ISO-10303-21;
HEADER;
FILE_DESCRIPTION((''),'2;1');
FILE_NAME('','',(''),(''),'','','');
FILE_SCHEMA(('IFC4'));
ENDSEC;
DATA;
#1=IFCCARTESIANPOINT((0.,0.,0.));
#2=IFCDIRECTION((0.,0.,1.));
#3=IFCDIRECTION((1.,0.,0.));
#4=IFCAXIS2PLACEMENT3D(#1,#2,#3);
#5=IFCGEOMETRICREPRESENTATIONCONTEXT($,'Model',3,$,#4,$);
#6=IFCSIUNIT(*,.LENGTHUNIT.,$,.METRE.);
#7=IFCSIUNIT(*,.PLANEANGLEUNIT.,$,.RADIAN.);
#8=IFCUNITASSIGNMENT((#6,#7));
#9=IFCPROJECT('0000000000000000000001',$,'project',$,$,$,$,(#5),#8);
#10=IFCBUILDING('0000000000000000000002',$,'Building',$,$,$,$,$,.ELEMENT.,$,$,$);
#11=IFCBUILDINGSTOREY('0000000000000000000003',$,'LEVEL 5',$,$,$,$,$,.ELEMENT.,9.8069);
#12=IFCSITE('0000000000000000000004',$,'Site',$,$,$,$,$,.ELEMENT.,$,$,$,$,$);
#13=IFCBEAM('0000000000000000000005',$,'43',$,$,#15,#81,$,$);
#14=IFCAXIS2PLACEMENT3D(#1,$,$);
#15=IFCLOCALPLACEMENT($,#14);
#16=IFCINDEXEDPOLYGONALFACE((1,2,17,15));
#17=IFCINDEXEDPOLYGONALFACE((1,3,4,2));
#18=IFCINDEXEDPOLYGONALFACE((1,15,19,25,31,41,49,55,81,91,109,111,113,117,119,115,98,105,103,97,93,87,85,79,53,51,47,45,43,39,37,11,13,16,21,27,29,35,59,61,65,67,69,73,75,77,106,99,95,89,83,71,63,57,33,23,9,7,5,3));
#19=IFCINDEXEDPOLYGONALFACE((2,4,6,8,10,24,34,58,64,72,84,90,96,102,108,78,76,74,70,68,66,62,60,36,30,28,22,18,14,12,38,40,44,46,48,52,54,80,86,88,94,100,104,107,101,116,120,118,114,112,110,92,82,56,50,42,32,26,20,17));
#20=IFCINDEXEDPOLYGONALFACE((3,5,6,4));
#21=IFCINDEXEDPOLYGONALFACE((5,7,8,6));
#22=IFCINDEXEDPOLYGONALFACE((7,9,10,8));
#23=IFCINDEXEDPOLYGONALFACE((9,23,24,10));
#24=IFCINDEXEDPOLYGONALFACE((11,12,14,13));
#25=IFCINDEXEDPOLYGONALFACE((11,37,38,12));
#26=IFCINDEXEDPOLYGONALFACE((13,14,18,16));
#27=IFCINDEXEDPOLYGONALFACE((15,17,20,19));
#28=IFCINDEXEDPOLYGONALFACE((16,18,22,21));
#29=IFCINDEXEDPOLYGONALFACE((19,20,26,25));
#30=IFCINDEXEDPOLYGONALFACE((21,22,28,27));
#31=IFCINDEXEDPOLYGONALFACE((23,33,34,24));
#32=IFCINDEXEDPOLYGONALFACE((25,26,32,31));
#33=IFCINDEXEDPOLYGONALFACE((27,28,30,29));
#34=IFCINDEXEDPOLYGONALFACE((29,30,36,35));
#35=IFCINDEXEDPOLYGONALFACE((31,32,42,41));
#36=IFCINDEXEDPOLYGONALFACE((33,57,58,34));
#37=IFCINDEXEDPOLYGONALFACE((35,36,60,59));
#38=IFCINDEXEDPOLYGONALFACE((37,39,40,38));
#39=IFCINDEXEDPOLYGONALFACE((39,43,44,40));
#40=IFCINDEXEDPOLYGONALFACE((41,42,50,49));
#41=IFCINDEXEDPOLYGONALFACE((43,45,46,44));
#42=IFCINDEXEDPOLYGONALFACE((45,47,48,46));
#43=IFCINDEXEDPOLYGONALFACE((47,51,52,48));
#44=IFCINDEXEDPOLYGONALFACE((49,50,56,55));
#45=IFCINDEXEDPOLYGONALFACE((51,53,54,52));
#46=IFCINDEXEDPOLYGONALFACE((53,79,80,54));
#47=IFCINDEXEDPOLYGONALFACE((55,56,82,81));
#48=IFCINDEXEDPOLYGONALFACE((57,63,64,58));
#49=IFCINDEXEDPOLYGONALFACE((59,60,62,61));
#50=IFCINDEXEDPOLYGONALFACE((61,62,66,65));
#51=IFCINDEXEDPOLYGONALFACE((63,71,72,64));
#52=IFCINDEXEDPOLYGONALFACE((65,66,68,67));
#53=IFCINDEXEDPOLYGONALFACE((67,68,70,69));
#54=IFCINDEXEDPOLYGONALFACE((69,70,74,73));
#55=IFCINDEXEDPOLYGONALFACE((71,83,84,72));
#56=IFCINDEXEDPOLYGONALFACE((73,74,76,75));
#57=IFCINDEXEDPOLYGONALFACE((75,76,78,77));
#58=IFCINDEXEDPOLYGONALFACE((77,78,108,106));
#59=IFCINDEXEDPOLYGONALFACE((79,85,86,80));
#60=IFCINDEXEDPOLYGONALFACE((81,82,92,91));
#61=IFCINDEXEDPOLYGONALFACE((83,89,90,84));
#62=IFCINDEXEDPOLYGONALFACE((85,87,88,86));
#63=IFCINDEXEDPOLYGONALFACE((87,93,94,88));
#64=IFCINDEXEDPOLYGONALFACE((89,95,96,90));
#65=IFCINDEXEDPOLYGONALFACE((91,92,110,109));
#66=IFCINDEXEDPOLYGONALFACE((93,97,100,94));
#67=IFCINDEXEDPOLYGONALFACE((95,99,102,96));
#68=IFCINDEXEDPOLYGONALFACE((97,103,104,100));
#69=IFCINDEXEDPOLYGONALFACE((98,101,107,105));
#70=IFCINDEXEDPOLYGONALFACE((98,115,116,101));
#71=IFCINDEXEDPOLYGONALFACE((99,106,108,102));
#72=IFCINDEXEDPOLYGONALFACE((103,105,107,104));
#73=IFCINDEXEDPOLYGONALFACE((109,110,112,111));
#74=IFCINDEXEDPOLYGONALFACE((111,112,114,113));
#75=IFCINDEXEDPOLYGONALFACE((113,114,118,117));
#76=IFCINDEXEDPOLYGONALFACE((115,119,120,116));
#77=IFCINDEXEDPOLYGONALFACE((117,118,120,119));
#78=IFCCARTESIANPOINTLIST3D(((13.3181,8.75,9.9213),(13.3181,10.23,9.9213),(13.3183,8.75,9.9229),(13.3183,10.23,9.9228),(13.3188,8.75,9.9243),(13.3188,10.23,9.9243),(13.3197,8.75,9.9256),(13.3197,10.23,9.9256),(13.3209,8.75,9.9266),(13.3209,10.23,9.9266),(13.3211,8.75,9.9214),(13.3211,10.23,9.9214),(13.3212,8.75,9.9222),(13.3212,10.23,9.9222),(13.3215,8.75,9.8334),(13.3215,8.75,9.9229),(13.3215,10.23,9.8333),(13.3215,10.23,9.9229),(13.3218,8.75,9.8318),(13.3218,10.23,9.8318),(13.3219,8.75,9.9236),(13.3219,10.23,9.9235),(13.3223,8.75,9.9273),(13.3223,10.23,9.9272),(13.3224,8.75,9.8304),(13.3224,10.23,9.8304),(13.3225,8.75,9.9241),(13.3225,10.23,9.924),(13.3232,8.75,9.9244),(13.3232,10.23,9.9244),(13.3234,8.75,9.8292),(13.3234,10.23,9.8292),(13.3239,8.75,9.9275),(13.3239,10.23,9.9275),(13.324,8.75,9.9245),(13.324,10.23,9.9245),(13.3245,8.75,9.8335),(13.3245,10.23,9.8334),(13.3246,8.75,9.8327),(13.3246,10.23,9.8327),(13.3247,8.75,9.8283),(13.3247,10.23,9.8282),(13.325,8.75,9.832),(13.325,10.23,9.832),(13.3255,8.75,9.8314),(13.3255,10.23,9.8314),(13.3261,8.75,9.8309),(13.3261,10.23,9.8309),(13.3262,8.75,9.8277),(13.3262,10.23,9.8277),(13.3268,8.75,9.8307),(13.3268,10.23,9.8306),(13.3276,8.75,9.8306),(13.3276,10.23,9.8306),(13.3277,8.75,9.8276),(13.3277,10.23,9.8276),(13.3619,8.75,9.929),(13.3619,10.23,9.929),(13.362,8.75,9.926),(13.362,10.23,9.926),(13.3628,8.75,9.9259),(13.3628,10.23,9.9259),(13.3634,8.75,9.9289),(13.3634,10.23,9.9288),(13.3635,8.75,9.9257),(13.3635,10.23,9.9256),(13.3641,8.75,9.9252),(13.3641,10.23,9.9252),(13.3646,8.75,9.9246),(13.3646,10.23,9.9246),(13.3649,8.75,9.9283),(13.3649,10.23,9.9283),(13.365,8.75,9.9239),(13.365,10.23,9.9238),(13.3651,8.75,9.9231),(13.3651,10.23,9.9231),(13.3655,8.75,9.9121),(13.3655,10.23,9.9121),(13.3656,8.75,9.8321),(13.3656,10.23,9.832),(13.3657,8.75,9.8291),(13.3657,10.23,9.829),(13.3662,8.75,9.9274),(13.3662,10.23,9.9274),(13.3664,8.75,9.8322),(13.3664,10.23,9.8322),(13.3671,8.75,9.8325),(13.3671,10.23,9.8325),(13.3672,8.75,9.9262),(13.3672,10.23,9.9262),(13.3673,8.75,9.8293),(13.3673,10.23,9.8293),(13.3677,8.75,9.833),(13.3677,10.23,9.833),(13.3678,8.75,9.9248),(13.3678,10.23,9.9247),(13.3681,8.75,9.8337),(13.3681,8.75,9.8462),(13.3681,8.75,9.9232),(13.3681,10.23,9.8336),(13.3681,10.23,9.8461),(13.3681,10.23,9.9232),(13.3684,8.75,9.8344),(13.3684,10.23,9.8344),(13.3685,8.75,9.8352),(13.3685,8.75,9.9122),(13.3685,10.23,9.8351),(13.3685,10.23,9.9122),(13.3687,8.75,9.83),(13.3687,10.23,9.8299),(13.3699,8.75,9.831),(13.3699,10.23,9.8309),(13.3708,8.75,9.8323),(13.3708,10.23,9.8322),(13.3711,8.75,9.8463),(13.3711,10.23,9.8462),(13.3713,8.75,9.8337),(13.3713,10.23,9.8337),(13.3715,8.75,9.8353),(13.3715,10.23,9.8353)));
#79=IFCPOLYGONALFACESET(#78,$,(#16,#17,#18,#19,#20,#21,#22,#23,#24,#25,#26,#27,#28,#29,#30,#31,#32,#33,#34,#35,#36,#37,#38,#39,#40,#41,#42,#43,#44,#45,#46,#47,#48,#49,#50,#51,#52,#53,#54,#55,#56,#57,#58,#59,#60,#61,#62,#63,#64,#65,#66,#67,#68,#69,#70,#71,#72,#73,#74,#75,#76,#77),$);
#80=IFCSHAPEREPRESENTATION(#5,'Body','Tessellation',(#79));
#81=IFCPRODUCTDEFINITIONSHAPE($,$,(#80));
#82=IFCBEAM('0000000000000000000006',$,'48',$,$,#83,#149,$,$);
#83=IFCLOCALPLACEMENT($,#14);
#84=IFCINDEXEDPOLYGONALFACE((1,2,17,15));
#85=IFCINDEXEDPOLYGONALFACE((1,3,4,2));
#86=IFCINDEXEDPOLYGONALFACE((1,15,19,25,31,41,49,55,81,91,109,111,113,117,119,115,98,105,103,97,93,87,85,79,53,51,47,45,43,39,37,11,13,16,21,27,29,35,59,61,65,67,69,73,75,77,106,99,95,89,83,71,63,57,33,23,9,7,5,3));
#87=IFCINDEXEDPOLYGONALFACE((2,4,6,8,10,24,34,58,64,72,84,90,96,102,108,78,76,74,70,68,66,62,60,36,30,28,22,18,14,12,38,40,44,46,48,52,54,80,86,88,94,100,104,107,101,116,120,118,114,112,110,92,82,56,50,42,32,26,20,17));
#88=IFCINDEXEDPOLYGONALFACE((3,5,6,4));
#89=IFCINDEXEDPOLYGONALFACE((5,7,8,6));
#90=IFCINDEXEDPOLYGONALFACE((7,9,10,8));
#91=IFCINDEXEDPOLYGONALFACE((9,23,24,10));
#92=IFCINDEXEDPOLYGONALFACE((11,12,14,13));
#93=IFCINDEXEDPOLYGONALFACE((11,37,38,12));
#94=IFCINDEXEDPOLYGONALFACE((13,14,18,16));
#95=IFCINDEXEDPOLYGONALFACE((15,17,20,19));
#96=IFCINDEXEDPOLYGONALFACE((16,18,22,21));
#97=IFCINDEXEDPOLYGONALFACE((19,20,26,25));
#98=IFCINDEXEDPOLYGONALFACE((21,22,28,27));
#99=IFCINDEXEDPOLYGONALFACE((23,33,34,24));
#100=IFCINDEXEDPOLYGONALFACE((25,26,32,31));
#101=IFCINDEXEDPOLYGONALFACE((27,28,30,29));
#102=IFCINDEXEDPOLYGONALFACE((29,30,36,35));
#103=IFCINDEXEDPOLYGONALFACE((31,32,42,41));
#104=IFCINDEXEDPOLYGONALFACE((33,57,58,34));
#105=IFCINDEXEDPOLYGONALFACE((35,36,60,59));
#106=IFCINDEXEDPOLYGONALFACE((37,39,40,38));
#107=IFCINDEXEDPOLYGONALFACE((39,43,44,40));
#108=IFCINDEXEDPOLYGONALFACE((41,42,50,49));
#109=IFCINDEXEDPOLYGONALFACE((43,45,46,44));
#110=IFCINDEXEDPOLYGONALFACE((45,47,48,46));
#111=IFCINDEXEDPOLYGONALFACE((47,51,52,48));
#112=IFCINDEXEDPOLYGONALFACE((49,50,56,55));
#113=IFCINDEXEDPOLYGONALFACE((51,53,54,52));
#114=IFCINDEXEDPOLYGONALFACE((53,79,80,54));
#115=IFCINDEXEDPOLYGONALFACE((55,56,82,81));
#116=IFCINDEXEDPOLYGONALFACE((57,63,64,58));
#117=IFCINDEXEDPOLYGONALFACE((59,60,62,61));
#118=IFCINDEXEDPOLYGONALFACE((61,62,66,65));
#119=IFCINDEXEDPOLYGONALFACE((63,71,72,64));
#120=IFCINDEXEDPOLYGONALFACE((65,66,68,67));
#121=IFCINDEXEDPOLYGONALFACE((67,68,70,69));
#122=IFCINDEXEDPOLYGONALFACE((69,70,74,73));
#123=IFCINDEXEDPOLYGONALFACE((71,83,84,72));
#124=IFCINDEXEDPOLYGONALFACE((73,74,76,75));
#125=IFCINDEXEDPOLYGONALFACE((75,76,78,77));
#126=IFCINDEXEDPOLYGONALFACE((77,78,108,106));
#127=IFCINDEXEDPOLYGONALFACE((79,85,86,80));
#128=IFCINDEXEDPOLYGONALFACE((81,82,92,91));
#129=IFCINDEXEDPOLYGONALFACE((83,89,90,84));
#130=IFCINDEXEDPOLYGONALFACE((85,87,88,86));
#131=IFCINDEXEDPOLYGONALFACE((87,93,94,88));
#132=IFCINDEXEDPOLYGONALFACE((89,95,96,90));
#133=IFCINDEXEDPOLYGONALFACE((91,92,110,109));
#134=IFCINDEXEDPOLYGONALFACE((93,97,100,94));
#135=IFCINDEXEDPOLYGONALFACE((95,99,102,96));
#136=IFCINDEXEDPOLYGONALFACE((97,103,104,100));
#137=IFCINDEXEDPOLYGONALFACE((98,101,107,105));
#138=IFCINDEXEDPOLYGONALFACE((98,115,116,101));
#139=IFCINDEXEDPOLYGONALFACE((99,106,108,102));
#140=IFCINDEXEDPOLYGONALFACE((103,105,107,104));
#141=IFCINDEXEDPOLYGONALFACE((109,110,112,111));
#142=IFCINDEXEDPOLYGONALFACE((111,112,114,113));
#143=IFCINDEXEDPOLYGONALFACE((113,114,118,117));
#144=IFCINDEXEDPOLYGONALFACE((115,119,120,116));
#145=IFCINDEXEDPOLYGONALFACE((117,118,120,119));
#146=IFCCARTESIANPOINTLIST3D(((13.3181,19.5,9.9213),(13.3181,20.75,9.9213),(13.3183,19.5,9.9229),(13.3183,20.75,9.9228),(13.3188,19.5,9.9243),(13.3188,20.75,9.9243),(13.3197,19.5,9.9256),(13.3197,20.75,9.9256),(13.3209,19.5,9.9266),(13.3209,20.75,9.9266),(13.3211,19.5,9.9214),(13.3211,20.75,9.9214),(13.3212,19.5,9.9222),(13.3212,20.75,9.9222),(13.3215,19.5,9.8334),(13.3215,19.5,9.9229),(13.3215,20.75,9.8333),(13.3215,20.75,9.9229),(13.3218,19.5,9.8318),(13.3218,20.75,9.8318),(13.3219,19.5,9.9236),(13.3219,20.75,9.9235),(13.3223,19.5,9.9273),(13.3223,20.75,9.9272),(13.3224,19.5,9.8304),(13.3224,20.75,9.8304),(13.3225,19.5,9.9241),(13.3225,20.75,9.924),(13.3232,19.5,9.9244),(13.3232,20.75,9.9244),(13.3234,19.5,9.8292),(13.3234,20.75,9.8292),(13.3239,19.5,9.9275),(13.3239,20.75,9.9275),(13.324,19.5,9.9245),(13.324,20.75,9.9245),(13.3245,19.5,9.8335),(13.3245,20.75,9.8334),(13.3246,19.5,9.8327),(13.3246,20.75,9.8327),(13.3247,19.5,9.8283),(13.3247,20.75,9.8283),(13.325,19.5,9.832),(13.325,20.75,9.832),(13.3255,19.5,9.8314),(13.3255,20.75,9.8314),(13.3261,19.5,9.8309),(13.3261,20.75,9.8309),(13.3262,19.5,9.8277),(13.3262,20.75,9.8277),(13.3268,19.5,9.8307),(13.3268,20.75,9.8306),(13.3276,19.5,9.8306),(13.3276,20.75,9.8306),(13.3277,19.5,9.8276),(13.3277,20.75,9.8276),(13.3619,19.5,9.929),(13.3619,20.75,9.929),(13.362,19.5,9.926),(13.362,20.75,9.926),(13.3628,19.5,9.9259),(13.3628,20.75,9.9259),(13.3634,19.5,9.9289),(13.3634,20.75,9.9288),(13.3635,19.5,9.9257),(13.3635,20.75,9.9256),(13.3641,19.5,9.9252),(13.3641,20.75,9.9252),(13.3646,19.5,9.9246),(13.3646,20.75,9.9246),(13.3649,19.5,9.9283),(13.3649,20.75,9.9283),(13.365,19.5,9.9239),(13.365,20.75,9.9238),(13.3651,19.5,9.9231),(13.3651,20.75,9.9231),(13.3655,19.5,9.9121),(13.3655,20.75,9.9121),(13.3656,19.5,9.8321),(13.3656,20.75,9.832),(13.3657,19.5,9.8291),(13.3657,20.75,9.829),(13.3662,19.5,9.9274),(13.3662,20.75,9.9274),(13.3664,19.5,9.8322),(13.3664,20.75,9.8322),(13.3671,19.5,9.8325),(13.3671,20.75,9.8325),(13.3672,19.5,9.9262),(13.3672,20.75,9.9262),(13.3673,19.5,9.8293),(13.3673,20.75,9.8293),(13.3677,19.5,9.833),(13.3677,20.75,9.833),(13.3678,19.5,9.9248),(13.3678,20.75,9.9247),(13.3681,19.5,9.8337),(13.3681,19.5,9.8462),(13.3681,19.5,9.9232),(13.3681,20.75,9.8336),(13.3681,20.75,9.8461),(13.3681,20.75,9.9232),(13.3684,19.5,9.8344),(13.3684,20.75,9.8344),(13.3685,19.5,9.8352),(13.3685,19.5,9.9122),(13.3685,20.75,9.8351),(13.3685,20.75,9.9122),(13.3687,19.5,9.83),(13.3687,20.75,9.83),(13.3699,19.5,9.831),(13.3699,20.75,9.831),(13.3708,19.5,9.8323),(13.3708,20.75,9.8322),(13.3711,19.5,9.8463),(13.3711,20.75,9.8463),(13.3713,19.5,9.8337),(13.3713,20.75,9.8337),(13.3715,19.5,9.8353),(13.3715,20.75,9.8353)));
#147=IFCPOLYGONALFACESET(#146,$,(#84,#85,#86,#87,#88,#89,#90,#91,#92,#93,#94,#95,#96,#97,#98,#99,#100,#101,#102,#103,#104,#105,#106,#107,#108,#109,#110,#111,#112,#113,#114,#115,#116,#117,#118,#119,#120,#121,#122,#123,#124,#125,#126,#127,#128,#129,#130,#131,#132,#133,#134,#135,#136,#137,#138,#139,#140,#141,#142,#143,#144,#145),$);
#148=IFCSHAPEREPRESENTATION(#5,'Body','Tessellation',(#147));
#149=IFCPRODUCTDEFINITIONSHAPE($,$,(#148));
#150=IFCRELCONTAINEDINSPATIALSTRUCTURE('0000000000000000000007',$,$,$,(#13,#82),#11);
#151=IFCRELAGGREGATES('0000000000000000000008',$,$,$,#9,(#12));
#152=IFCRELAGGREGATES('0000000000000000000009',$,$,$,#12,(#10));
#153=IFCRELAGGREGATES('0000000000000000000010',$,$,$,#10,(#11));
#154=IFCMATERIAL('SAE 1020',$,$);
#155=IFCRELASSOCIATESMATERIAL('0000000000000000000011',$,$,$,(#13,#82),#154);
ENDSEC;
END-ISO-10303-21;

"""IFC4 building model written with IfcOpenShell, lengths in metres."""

from ifc_helpers import new_model, si_unit, frame, origin_with_axes, origin_2d_with_axis, place, context, project, spatial, c_section, extrude, material, material_profile, profile_set, profile_usage, element, save


model = new_model("IFC4")

# Units and contexts
model_context = context("Model", 3, world=origin_with_axes())
ifc_project = project(units=[si_unit("LENGTHUNIT", "METRE"), si_unit("PLANEANGLEUNIT", "RADIAN")], contexts=[model_context])

# Site, building, storey
site = spatial("IfcSite", under=ifc_project, Name="Site", CompositionType="ELEMENT")
building = spatial("IfcBuilding", under=site, Name="Building", CompositionType="ELEMENT")
storey = spatial("IfcBuildingStorey", under=building, Name="LEVEL 5", CompositionType="ELEMENT", Elevation=9.8069)

# Beams
ifc_material = material(Name="SAE 1020")
ifc_material_profile_1 = material_profile(ifc_material, c_section(Depth=0.1, Width=0.05, WallThickness=0.003, Girth=0.017, InternalFilletRadius=0.003, at=origin_2d_with_axis()))
ifc_profile_set_1 = profile_set([ifc_material_profile_1])
ifc_profile_usage_1 = profile_usage(ifc_profile_set_1, cardinal=10)
beam_1_placement = place(None, frame((13.3448, 8.75, 9.8783), z_axis=(0.0, 1.0, -0.00003), x_axis=(0.999256, 0.000001, 0.038562)))
element("IfcBeam", 1, at=beam_1_placement, inside=storey, material=ifc_profile_usage_1, Name="43", context=model_context, shape_type="SweptSolid", body=[
    extrude(c_section(Depth=0.1, Width=0.05, WallThickness=0.003, Girth=0.017, InternalFilletRadius=0.003, at=origin_2d_with_axis()), origin_with_axes(), (0.0, 0.0, 1.0), 1.48),
])
ifc_material_profile_2 = material_profile(ifc_material, c_section(Depth=0.1, Width=0.05, WallThickness=0.003, Girth=0.017, InternalFilletRadius=0.003, at=origin_2d_with_axis()))
ifc_profile_set_2 = profile_set([ifc_material_profile_2])
ifc_profile_usage_2 = profile_usage(ifc_profile_set_2, cardinal=10)
beam_2_placement = place(None, frame((13.3448, 19.5, 9.8783), z_axis=(0.0, 1.0, -0.00003), x_axis=(0.999256, 0.000001, 0.038562)))
element("IfcBeam", 2, at=beam_2_placement, inside=storey, material=ifc_profile_usage_2, Name="48", context=model_context, shape_type="SweptSolid", body=[
    extrude(c_section(Depth=0.1, Width=0.05, WallThickness=0.003, Girth=0.017, InternalFilletRadius=0.003, at=origin_2d_with_axis()), origin_with_axes(), (0.0, 0.0, 1.0), 1.25),
])

save(model, "model.ifc")
